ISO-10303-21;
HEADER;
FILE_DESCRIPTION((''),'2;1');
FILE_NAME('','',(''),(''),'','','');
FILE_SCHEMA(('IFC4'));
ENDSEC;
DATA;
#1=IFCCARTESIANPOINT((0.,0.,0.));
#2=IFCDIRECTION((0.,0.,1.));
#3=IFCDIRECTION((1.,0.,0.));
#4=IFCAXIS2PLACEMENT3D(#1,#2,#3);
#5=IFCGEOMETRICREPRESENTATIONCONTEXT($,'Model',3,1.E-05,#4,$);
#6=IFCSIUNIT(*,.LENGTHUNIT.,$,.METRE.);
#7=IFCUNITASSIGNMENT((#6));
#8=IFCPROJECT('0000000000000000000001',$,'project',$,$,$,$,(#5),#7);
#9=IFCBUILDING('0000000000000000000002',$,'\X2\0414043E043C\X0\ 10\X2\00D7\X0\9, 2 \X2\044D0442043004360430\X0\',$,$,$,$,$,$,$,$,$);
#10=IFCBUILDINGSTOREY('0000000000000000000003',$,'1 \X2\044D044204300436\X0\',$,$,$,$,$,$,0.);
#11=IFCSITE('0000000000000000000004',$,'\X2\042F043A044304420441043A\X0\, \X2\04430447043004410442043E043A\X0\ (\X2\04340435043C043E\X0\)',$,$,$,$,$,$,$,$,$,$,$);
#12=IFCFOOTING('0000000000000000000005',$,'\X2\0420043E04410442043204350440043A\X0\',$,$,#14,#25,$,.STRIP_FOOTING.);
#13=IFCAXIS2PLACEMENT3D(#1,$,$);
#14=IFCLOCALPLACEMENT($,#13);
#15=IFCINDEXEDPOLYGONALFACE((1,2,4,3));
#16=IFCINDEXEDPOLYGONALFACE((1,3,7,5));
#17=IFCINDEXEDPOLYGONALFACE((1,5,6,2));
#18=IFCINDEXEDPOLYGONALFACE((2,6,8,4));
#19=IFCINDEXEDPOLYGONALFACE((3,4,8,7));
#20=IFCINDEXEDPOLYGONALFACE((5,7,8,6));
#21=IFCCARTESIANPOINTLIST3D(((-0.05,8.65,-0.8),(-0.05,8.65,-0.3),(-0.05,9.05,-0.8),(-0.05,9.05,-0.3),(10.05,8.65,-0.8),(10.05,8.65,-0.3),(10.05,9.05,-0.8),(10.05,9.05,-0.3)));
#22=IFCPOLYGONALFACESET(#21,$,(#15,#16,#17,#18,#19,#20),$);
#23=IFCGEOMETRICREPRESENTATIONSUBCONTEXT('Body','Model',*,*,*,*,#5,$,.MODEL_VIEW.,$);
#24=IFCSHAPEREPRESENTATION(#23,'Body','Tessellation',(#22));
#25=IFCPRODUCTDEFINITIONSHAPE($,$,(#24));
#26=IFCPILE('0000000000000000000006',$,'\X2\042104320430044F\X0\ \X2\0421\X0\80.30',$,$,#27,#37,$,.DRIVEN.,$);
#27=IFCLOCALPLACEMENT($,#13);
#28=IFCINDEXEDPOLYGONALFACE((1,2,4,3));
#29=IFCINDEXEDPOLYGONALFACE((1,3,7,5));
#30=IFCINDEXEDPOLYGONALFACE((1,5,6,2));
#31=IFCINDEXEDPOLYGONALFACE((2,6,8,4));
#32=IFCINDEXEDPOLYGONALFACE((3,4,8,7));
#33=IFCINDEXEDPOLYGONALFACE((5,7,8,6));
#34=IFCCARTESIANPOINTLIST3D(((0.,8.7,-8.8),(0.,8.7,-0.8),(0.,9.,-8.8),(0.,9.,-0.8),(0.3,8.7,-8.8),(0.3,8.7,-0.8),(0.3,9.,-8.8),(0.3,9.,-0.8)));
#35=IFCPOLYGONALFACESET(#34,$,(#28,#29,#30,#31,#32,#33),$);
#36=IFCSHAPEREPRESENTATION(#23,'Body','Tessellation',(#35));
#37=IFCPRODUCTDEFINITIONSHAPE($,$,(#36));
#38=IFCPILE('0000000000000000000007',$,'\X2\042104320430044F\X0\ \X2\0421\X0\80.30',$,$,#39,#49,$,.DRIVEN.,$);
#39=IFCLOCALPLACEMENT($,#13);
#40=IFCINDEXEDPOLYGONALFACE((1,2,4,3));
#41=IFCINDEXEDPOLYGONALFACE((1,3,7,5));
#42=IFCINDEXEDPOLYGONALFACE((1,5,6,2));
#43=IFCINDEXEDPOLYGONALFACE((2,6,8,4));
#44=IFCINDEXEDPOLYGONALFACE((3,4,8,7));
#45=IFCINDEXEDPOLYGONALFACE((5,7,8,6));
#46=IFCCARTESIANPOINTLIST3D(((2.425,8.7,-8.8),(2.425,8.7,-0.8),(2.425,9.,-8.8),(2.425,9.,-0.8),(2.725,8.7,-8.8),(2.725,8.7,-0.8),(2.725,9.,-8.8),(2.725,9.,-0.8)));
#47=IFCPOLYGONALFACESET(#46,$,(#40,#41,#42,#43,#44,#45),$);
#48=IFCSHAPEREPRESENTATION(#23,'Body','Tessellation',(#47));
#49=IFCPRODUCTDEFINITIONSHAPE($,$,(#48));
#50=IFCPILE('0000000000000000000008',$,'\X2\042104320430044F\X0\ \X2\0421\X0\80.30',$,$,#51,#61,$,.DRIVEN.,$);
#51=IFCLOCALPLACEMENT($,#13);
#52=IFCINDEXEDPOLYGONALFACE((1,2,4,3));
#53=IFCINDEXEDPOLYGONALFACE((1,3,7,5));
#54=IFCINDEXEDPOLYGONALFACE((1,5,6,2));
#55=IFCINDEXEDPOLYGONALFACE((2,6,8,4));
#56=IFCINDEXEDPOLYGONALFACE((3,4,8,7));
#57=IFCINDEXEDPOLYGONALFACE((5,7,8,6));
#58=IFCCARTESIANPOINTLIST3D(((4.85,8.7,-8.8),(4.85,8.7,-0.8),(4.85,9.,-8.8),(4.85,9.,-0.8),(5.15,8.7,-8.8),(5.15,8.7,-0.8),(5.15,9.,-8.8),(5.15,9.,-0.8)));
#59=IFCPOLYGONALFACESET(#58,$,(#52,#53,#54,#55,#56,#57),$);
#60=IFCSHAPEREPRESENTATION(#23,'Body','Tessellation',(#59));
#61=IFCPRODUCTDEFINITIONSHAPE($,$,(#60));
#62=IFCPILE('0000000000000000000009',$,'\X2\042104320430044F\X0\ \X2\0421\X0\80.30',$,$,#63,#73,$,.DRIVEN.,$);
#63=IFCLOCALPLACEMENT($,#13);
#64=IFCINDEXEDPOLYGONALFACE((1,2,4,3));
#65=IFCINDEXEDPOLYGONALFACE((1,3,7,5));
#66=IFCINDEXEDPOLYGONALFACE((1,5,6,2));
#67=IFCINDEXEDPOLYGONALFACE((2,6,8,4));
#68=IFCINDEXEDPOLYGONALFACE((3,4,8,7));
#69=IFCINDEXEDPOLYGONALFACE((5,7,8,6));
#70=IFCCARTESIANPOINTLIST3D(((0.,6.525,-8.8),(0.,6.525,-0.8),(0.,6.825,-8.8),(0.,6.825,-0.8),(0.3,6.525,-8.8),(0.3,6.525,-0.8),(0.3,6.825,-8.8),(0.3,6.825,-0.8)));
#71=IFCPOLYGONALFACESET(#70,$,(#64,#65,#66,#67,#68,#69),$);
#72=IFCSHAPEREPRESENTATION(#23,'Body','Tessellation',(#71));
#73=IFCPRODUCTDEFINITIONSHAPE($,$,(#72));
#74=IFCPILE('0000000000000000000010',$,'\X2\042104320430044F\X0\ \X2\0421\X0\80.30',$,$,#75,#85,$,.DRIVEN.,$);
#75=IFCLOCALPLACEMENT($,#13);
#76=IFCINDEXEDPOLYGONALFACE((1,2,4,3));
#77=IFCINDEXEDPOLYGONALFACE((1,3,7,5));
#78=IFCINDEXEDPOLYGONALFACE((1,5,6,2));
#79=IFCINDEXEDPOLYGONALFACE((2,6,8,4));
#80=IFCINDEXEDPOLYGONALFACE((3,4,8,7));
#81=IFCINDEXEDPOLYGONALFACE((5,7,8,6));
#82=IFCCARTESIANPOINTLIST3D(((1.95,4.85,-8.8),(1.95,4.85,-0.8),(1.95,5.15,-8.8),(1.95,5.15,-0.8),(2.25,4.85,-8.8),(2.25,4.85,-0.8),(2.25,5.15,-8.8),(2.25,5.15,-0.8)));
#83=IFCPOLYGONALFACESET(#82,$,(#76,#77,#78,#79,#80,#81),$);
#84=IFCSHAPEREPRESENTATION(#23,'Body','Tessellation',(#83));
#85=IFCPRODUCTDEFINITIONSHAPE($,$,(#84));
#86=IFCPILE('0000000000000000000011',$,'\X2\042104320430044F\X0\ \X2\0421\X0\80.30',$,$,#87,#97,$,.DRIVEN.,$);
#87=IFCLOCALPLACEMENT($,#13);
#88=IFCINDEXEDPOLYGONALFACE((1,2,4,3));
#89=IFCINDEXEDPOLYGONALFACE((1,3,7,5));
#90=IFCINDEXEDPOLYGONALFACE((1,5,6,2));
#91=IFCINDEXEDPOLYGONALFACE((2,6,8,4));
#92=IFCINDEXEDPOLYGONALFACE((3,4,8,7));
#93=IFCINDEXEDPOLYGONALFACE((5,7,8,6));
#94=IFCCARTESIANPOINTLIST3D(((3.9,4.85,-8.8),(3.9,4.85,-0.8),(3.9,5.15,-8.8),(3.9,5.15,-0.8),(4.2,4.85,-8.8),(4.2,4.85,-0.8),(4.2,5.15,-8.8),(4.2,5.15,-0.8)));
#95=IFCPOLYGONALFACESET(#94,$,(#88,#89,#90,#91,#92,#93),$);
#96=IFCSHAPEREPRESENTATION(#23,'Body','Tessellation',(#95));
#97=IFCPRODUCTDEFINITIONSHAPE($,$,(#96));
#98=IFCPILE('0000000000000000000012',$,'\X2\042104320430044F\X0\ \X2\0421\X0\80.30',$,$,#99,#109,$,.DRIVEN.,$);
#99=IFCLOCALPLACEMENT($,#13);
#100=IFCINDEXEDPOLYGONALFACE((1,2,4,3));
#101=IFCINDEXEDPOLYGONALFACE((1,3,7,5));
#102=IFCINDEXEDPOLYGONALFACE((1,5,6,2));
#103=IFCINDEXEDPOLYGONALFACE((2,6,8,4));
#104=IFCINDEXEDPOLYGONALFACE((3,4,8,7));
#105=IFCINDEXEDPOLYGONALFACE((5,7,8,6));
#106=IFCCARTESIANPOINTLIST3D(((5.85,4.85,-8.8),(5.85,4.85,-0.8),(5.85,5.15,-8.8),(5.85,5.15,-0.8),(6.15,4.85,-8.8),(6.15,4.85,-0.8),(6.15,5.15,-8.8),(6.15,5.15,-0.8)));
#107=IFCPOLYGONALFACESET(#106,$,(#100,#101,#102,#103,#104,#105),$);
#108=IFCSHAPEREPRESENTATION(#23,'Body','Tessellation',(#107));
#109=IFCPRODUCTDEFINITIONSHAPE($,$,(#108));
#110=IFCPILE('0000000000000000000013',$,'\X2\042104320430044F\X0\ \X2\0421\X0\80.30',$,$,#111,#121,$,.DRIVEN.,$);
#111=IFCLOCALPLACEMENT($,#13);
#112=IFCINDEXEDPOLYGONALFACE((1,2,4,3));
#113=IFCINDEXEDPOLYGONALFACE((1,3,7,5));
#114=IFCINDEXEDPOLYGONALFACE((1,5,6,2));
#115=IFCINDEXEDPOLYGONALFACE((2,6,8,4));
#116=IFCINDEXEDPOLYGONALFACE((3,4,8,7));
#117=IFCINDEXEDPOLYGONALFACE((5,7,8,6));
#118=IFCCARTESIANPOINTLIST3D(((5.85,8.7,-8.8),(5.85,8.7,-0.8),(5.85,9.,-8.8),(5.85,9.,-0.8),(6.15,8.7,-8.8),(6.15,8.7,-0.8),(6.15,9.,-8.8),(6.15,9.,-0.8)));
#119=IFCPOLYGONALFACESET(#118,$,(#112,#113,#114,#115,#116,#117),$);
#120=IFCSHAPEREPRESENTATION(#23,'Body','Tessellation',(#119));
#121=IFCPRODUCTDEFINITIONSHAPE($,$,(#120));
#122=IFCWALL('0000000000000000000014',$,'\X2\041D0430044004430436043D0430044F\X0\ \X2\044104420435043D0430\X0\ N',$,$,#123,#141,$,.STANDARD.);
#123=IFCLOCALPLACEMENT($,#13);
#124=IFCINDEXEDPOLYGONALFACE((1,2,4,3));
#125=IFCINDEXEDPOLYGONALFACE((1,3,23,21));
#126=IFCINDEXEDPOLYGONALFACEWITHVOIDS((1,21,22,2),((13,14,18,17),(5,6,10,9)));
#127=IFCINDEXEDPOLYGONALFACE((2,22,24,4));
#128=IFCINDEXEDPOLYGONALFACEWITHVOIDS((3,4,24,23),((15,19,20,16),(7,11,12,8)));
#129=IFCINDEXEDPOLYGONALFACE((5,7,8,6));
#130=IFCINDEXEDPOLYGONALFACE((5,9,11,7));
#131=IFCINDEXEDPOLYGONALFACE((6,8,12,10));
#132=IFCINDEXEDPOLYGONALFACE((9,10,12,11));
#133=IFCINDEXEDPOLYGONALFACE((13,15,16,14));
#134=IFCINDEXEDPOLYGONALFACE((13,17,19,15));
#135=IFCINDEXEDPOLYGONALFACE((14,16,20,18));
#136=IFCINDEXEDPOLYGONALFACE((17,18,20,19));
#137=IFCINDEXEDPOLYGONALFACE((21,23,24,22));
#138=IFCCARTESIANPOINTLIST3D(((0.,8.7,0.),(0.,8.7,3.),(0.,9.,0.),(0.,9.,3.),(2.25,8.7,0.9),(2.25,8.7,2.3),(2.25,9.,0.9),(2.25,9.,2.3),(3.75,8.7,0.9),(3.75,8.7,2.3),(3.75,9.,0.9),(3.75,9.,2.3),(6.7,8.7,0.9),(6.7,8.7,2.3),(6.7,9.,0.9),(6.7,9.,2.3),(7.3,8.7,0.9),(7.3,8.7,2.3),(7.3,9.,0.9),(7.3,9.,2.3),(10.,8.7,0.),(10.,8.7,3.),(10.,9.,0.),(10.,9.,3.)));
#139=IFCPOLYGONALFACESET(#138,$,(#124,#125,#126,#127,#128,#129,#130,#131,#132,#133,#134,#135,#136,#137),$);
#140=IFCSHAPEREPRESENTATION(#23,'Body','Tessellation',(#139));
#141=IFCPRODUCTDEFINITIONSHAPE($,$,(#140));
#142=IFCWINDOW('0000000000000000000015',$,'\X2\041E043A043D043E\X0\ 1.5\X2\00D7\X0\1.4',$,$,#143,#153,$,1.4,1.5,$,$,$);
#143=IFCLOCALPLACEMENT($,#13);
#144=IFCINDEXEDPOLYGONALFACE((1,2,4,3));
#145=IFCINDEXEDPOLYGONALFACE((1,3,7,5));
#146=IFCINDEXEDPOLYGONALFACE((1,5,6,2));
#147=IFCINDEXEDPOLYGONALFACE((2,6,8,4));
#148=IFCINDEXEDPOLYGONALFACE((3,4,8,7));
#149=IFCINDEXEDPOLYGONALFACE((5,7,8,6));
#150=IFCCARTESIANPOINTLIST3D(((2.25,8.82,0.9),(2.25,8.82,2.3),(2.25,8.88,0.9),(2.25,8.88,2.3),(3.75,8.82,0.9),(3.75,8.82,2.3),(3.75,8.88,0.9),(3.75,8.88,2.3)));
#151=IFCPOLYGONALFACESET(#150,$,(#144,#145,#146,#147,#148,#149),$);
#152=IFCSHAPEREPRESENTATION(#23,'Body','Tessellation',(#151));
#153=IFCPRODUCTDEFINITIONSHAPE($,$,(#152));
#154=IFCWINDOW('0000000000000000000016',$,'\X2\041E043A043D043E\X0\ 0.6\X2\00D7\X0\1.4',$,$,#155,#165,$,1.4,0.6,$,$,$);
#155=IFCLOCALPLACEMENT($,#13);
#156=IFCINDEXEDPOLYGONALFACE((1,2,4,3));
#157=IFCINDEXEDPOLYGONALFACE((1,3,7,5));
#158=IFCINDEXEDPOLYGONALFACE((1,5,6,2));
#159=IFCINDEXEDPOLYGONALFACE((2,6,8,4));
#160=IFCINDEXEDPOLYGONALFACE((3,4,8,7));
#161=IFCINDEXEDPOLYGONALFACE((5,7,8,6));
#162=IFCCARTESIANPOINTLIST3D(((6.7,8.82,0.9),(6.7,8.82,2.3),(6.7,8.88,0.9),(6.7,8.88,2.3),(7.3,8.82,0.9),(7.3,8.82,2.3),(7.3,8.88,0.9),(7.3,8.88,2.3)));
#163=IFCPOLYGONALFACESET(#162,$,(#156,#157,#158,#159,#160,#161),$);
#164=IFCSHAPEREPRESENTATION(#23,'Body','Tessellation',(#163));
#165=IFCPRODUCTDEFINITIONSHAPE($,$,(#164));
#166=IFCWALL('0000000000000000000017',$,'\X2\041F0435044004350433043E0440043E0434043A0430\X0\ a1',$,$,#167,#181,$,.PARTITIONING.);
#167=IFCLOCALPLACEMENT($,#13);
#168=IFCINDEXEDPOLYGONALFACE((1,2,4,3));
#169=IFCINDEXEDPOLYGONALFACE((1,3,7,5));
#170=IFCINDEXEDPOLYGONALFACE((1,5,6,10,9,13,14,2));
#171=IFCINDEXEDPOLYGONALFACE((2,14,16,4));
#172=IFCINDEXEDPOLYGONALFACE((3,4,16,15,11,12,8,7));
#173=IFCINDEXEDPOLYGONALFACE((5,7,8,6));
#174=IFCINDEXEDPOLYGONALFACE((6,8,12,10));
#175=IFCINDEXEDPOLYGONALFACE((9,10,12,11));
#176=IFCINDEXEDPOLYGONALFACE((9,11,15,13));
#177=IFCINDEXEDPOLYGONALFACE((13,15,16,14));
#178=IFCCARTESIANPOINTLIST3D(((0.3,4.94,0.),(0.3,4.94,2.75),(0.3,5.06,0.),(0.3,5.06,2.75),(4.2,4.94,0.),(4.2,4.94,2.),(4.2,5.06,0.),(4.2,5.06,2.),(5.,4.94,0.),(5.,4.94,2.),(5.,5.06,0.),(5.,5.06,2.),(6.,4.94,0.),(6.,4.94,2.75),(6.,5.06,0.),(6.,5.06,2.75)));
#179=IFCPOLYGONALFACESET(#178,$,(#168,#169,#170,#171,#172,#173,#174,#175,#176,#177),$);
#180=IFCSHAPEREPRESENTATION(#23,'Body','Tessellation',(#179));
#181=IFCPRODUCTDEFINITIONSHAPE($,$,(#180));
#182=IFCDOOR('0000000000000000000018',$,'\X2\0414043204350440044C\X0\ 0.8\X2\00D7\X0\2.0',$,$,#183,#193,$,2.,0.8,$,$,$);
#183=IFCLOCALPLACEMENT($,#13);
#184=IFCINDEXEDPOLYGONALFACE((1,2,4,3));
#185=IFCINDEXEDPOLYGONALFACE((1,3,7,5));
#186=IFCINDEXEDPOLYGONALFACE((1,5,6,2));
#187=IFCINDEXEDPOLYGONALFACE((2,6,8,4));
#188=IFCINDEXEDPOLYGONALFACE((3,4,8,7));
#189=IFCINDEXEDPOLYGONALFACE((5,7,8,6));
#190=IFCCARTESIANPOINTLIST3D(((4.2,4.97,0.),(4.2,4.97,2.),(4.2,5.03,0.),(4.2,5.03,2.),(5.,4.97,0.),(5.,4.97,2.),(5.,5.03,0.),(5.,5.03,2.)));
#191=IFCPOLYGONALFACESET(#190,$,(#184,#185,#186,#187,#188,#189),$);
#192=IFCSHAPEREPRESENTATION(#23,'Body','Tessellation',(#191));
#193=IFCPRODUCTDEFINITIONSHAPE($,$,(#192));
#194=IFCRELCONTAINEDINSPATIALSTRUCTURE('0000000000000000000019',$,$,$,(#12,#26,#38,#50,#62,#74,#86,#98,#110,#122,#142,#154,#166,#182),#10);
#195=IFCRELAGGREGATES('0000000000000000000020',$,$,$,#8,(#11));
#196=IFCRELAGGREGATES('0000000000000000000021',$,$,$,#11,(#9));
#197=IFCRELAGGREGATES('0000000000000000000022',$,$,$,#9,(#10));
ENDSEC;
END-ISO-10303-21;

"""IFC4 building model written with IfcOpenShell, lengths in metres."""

from ifc_helpers import new_model, si_unit, frame, origin_with_axes, place, context, subcontext, project, spatial, indexed_curve, rectangle, outline, extrude, element, fill, save


model = new_model("IFC4")

# Units and contexts
model_context = context("Model", 3, precision=1e-05, world=origin_with_axes())
body_context = subcontext(model_context, "Body", "Model", "MODEL_VIEW")
ifc_project = project(units=[si_unit("LENGTHUNIT", "METRE")], contexts=[model_context])

# Site, building, storey
site = spatial("IfcSite", under=ifc_project, Name="Якутск, участок (демо)")
building = spatial("IfcBuilding", under=site, Name="Дом 10×9, 2 этажа")
storey = spatial("IfcBuildingStorey", under=building, Name="1 этаж", Elevation=0.0)

# Footing
footing_placement = place(None, frame((-0.05, 8.65, -0.8), z_axis=(0.0, 0.0, 1.0), x_axis=(1.0, 0.0, 0.0)))
element("IfcFooting", 1, at=footing_placement, inside=storey, Name="Ростверк", PredefinedType="STRIP_FOOTING", context=body_context, shape_type="SweptSolid", body=[
    extrude(outline(indexed_curve([(0.0, 0.0), (0.0, 0.4), (10.1, 0.4), (10.1, 0.0), (0.0, 0.0)], self_intersect=False)), origin_with_axes(), (0.0, 0.0, 1.0), 0.5),
])

# Piles
for number, where, z_axis, x_axis, name in (
    (2, (0.15, 8.85, -8.8), (0.0, 0.0, 1.0), (1.0, 0.0, 0.0), "Свая С80.30"),
    (3, (2.575, 8.85, -8.8), (0.0, 0.0, 1.0), (1.0, 0.0, 0.0), "Свая С80.30"),
    (4, (5.0, 8.85, -8.8), (0.0, 0.0, 1.0), (1.0, 0.0, 0.0), "Свая С80.30"),
    (5, (0.15, 6.675, -8.8), (0.0, 0.0, 1.0), (1.0, 0.0, 0.0), "Свая С80.30"),
    (6, (2.1, 5.0, -8.8), (0.0, 0.0, 1.0), (1.0, 0.0, 0.0), "Свая С80.30"),
    (7, (4.05, 5.0, -8.8), (0.0, 0.0, 1.0), (1.0, 0.0, 0.0), "Свая С80.30"),
    (8, (6.0, 5.0, -8.8), (0.0, 0.0, 1.0), (1.0, 0.0, 0.0), "Свая С80.30"),
    (9, (6.0, 8.85, -8.8), (0.0, 0.0, 1.0), (1.0, 0.0, 0.0), "Свая С80.30"),
):
    element("IfcPile", number, at=place(None, frame(where, z_axis=z_axis, x_axis=x_axis)), inside=storey, Name=name, PredefinedType="DRIVEN", context=body_context, shape_type="SweptSolid", body=[
        extrude(rectangle(XDim=0.3, YDim=0.3), origin_with_axes(), (0.0, 0.0, 1.0), 8.0),
    ])

# Wall, openings, windows
wall_1_placement = place(None, frame((0.0, 8.7, 0.0), z_axis=(0.0, 0.0, 1.0), x_axis=(1.0, 0.0, 0.0)))
wall_1 = element("IfcWall", 10, at=wall_1_placement, inside=storey, Name="Наружная стена N", PredefinedType="STANDARD", context=body_context, shape_type="SweptSolid", body=[
    extrude(outline(indexed_curve([(0.0, 0.0), (0.0, 0.3), (10.0, 0.3), (10.0, 0.0), (0.0, 0.0)], self_intersect=False)), origin_with_axes(), (0.0, 0.0, 1.0), 3.0),
])
opening_1_placement = place(wall_1_placement, frame((2.25, -0.05, 0.9), z_axis=(0.0, 0.0, 1.0), x_axis=(1.0, 0.0, 0.0)))
opening_1 = element("IfcOpeningElement", 11, at=opening_1_placement, cuts=wall_1, context=body_context, shape_type="SweptSolid", body=[
    extrude(outline(indexed_curve([(0.0, 0.0), (0.0, 0.4), (1.5, 0.4), (1.5, 0.0), (0.0, 0.0)], self_intersect=False)), origin_with_axes(), (0.0, 0.0, 1.0), 1.4),
])
opening_2_placement = place(wall_1_placement, frame((6.7, -0.05, 0.9), z_axis=(0.0, 0.0, 1.0), x_axis=(1.0, 0.0, 0.0)))
opening_2 = element("IfcOpeningElement", 12, at=opening_2_placement, cuts=wall_1, context=body_context, shape_type="SweptSolid", body=[
    extrude(outline(indexed_curve([(0.0, 0.0), (0.0, 0.4), (0.6, 0.4), (0.6, 0.0), (0.0, 0.0)], self_intersect=False)), origin_with_axes(), (0.0, 0.0, 1.0), 1.4),
])
window_1_placement = place(opening_1_placement, frame((0.0, 0.17, 0.0), z_axis=(0.0, 0.0, 1.0), x_axis=(1.0, 0.0, 0.0)))
window_1 = element("IfcWindow", 13, at=window_1_placement, inside=storey, Name="Окно 1.5×1.4", OverallHeight=1.4, OverallWidth=1.5, context=body_context, shape_type="SweptSolid", body=[
    extrude(outline(indexed_curve([(0.0, 0.0), (0.0, 0.06), (1.5, 0.06), (1.5, 0.0), (0.0, 0.0)], self_intersect=False)), origin_with_axes(), (0.0, 0.0, 1.0), 1.4),
])
fill(opening_1, window_1)
window_2_placement = place(opening_2_placement, frame((0.0, 0.17, 0.0), z_axis=(0.0, 0.0, 1.0), x_axis=(1.0, 0.0, 0.0)))
window_2 = element("IfcWindow", 14, at=window_2_placement, inside=storey, Name="Окно 0.6×1.4", OverallHeight=1.4, OverallWidth=0.6, context=body_context, shape_type="SweptSolid", body=[
    extrude(outline(indexed_curve([(0.0, 0.0), (0.0, 0.06), (0.6, 0.06), (0.6, 0.0), (0.0, 0.0)], self_intersect=False)), origin_with_axes(), (0.0, 0.0, 1.0), 1.4),
])
fill(opening_2, window_2)

# Wall, opening, door
wall_2_placement = place(None, frame((0.3, 4.94, 0.0), z_axis=(0.0, 0.0, 1.0), x_axis=(1.0, 0.0, 0.0)))
wall_2 = element("IfcWall", 15, at=wall_2_placement, inside=storey, Name="Перегородка a1", PredefinedType="PARTITIONING", context=body_context, shape_type="SweptSolid", body=[
    extrude(outline(indexed_curve([(0.0, 0.0), (0.0, 0.12), (5.7, 0.12), (5.7, 0.0), (0.0, 0.0)], self_intersect=False)), origin_with_axes(), (0.0, 0.0, 1.0), 2.75),
])
opening_3_placement = place(wall_2_placement, frame((3.9, -0.05, 0.0), z_axis=(0.0, 0.0, 1.0), x_axis=(1.0, 0.0, 0.0)))
opening_3 = element("IfcOpeningElement", 16, at=opening_3_placement, cuts=wall_2, context=body_context, shape_type="SweptSolid", body=[
    extrude(outline(indexed_curve([(0.0, 0.0), (0.0, 0.22), (0.8, 0.22), (0.8, 0.0), (0.0, 0.0)], self_intersect=False)), origin_with_axes(), (0.0, 0.0, 1.0), 2.0),
])
door_1_placement = place(opening_3_placement, frame((0.0, 0.08, 0.0), z_axis=(0.0, 0.0, 1.0), x_axis=(1.0, 0.0, 0.0)))
door_1 = element("IfcDoor", 17, at=door_1_placement, inside=storey, Name="Дверь 0.8×2.0", OverallHeight=2.0, OverallWidth=0.8, context=body_context, shape_type="SweptSolid", body=[
    extrude(outline(indexed_curve([(0.0, 0.0), (0.0, 0.06), (0.8, 0.06), (0.8, 0.0), (0.0, 0.0)], self_intersect=False)), origin_with_axes(), (0.0, 0.0, 1.0), 2.0),
])
fill(opening_3, door_1)

save(model, "model.ifc")
